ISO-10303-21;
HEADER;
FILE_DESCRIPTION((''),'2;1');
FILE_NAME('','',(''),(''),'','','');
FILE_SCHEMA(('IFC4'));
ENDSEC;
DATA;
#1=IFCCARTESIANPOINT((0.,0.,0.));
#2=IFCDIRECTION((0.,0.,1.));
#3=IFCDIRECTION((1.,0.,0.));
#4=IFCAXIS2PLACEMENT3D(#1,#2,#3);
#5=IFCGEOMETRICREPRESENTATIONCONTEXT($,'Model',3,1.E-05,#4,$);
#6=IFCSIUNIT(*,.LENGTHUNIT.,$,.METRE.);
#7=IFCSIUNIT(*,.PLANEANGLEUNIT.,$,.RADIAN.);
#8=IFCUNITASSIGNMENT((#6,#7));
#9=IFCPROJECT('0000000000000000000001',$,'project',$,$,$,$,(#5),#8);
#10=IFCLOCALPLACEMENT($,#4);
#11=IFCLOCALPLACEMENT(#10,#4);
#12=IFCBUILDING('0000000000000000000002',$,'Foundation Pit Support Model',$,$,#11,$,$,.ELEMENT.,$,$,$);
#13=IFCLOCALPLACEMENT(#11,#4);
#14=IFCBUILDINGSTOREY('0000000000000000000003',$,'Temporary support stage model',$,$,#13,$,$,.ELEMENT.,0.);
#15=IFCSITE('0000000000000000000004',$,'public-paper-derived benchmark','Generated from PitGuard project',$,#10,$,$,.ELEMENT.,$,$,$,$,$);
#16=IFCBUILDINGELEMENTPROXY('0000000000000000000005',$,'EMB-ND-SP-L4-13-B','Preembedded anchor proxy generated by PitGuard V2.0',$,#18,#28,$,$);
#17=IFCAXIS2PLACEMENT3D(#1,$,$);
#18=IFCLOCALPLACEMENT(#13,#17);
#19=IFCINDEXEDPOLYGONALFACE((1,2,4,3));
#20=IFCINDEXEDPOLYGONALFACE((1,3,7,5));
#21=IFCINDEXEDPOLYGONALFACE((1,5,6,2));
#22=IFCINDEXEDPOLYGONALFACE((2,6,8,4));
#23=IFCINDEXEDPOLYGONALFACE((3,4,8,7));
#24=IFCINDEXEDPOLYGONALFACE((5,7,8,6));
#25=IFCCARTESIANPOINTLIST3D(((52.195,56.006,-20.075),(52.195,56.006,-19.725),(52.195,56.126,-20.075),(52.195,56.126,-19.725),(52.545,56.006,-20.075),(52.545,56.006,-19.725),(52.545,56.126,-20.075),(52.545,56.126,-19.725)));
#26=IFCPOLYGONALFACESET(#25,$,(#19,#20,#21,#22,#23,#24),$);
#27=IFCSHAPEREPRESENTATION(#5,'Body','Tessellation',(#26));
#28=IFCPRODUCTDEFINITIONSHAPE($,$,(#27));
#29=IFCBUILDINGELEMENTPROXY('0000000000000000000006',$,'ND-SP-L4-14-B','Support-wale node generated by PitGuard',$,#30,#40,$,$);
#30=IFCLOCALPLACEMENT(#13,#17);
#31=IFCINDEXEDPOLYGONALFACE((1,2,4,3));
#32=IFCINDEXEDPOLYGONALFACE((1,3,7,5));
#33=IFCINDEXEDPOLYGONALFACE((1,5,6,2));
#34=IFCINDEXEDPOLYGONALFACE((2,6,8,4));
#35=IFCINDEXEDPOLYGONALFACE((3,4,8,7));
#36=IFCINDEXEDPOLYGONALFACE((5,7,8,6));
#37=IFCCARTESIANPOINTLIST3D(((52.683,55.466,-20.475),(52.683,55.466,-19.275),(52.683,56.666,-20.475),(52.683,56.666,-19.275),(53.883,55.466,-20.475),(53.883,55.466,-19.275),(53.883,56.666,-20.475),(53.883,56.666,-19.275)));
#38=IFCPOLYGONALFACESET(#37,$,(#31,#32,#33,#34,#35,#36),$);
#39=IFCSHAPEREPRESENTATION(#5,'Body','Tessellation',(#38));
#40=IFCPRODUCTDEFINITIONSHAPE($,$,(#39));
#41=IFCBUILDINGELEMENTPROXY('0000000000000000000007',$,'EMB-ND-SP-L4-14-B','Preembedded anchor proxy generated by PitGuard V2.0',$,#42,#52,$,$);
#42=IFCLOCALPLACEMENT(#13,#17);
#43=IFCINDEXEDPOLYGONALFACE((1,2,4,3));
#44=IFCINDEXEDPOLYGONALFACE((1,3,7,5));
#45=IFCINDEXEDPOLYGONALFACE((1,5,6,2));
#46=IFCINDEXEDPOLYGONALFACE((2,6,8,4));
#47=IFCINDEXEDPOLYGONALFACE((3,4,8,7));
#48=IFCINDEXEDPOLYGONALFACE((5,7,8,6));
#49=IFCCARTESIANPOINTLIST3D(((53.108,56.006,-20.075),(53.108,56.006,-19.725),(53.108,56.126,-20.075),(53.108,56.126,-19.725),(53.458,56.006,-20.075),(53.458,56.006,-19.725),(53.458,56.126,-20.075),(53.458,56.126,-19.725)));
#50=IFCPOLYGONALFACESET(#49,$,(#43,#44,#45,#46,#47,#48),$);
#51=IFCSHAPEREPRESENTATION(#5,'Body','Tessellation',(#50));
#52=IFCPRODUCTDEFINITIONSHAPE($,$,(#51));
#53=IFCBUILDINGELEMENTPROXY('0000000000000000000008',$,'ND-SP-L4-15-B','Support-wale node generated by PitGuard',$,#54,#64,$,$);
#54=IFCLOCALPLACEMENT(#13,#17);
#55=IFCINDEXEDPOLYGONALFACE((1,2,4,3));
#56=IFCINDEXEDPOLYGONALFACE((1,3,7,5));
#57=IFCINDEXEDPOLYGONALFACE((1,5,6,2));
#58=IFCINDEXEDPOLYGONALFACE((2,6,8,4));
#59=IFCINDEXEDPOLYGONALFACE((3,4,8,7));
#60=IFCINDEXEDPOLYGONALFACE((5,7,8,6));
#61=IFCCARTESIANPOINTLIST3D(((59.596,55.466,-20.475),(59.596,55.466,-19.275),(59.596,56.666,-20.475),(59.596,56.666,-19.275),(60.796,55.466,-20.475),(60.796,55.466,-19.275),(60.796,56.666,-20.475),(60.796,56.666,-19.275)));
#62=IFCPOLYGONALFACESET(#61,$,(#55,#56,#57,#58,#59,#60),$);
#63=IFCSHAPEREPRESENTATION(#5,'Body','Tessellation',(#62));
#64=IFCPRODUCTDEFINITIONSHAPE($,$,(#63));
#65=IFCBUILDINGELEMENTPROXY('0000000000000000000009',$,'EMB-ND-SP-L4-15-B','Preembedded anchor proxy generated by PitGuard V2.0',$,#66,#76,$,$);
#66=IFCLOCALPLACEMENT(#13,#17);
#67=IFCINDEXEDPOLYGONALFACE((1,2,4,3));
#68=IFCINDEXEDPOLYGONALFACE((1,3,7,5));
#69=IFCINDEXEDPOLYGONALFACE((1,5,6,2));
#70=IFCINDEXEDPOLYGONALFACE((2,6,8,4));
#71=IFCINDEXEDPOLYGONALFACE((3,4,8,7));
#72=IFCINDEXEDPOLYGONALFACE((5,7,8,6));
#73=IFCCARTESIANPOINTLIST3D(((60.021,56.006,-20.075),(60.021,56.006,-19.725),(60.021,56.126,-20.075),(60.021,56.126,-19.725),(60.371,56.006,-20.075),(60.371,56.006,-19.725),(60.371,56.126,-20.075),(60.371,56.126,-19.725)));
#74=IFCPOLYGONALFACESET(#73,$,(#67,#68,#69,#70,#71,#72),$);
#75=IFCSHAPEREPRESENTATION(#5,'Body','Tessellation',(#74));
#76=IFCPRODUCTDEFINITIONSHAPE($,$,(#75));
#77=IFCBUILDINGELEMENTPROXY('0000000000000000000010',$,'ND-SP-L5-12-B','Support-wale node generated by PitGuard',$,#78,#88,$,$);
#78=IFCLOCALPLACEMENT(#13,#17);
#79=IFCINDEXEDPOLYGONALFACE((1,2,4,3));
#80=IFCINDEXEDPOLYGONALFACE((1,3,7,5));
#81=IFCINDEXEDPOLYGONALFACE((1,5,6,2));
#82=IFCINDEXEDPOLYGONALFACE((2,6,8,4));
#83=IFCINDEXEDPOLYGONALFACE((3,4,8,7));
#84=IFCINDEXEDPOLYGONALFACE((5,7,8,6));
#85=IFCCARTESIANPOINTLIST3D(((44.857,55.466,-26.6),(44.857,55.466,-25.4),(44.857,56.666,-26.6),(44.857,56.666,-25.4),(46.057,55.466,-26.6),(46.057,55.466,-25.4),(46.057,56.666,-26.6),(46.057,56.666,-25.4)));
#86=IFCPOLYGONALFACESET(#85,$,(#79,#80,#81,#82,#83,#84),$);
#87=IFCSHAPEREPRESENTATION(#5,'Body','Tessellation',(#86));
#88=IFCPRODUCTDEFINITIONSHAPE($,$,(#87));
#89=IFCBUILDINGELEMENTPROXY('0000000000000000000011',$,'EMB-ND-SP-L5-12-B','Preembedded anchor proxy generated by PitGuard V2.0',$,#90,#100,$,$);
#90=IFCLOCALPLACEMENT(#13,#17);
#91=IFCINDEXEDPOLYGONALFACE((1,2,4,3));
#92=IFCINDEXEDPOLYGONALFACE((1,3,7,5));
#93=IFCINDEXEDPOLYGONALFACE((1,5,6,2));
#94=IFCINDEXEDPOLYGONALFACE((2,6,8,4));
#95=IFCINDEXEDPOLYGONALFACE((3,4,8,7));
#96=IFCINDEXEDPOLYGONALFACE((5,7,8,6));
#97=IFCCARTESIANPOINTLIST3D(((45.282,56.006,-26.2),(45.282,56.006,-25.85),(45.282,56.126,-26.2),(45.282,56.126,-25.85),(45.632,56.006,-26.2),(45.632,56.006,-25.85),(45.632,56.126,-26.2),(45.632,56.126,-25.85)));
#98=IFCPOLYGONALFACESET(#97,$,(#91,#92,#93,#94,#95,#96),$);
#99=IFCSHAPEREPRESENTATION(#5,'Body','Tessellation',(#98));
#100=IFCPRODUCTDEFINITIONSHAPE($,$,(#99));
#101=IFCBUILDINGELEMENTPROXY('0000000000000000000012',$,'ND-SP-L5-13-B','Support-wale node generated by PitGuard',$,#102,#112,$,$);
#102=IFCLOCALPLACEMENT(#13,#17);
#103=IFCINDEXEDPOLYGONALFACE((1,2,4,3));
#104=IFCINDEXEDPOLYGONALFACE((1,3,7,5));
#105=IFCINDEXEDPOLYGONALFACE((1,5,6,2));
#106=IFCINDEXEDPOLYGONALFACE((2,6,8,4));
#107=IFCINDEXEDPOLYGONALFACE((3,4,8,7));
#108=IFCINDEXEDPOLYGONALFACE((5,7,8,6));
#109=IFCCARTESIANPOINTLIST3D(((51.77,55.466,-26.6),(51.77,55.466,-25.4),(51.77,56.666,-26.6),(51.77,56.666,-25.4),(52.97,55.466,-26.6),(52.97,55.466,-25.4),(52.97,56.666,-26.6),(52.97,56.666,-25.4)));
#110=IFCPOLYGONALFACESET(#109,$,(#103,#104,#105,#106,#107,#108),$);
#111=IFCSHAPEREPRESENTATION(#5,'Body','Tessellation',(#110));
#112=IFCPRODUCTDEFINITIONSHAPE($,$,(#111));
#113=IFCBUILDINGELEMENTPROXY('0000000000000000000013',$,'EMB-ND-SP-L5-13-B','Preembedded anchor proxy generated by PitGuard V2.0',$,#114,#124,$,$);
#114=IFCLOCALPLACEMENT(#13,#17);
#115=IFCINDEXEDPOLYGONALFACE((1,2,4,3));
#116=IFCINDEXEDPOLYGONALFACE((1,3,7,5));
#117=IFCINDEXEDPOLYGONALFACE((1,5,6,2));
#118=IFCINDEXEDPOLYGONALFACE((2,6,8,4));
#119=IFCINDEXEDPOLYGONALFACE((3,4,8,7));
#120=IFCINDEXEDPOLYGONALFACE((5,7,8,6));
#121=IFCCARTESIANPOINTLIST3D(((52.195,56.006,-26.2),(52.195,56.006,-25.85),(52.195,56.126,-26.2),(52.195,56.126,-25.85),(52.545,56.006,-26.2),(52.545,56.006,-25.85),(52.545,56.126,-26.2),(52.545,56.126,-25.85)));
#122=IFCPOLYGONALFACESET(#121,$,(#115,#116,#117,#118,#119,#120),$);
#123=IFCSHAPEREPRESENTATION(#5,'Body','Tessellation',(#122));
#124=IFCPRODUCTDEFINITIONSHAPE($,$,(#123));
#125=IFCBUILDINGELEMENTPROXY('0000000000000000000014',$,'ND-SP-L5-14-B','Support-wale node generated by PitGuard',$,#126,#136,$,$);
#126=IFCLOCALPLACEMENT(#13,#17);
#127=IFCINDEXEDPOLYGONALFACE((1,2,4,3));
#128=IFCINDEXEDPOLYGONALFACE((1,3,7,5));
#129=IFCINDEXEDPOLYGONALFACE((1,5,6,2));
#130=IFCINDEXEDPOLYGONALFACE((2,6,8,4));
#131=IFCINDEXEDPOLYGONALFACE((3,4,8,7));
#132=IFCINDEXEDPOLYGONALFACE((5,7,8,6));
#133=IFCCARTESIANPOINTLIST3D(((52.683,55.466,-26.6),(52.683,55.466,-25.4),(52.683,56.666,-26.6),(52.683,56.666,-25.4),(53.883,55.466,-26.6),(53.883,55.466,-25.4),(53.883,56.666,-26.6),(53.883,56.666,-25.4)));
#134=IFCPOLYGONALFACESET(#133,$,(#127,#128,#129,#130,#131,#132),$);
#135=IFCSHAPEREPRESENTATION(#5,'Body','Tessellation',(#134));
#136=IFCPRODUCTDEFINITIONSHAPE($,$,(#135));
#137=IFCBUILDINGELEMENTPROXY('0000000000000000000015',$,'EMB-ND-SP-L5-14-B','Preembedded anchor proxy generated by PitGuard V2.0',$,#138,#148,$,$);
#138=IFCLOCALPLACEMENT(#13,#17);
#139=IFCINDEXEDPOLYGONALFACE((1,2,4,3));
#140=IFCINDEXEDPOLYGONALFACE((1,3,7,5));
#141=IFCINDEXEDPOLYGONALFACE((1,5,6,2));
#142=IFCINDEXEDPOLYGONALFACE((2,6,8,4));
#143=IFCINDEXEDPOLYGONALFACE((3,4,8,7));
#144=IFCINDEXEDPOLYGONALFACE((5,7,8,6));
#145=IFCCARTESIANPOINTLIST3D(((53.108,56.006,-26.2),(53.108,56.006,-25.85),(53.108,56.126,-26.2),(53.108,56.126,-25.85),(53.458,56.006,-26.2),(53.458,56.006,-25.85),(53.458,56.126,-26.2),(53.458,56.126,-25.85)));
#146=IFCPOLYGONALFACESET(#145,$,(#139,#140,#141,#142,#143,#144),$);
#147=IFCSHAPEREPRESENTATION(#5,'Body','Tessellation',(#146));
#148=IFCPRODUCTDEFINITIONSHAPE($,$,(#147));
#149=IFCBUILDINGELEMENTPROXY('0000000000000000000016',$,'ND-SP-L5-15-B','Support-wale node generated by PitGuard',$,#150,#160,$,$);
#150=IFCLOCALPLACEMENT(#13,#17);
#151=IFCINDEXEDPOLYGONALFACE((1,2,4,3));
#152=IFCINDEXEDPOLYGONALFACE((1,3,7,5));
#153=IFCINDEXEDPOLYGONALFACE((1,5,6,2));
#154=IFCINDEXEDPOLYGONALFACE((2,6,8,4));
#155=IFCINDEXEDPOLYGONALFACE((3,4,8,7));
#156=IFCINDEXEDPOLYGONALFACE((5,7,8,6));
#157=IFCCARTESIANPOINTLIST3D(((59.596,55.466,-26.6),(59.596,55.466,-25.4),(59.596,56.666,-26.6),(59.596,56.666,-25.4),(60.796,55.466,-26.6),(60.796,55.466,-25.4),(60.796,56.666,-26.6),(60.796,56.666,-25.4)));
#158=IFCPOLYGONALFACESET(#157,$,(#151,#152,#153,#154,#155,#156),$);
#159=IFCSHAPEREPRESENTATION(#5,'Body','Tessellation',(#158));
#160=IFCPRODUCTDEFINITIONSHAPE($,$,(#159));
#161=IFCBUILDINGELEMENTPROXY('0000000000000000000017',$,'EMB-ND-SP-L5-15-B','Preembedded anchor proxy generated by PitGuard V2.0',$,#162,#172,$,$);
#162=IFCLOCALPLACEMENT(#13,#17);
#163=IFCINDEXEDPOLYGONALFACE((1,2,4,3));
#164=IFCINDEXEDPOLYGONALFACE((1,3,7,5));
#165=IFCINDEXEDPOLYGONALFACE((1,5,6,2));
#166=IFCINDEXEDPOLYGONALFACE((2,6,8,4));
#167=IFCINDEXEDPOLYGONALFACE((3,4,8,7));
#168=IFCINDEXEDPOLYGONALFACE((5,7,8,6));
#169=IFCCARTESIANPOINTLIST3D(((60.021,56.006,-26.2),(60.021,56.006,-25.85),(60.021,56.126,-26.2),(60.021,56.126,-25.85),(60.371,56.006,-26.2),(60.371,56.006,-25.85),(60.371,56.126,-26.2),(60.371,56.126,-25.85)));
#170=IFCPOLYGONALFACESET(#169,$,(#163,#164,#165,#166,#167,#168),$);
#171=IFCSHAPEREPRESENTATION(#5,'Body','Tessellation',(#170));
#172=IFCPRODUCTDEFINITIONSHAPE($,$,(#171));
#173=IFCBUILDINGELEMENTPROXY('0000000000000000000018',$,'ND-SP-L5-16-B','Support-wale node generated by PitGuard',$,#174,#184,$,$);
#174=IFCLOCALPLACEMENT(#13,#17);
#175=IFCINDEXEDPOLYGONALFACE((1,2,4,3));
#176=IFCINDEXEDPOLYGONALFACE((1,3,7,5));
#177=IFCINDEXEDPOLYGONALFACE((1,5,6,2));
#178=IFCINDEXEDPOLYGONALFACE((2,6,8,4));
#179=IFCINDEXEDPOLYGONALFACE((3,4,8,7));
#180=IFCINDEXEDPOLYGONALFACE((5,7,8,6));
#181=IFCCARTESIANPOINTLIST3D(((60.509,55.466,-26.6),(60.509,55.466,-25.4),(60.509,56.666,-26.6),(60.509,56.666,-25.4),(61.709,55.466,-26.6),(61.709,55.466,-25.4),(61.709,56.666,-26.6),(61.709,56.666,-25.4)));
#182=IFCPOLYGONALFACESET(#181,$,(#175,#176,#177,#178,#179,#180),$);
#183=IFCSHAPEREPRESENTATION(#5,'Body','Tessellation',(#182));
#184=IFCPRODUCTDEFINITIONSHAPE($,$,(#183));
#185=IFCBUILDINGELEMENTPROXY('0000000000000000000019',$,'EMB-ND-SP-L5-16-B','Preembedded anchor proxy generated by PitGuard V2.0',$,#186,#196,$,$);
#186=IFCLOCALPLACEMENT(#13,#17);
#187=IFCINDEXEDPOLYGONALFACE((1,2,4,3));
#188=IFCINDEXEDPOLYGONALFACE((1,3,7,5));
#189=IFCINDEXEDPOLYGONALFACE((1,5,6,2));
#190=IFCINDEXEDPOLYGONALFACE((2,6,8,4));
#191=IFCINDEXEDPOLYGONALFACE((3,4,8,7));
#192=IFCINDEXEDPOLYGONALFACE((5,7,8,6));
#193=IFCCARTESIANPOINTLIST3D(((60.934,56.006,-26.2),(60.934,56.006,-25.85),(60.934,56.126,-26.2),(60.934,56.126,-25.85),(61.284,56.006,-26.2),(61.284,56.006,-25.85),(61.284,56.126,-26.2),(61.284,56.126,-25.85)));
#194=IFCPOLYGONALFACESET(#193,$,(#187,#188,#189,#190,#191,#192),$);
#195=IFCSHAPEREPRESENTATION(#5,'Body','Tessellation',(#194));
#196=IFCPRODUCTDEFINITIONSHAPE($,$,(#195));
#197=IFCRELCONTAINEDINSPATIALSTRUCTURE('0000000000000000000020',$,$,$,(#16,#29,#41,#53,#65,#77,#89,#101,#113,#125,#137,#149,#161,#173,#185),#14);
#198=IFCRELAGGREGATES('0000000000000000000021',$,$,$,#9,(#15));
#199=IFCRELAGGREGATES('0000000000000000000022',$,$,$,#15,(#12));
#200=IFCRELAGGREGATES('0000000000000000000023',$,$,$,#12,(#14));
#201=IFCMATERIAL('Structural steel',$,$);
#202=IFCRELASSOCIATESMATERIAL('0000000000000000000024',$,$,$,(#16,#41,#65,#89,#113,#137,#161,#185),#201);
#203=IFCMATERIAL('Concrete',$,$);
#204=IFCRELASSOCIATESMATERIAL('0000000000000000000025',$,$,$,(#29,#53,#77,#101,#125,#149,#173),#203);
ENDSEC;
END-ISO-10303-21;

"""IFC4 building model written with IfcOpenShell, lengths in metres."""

from ifc_helpers import new_model, si_unit, frame, origin_with_axes, origin_2d, place, context, project, spatial, rectangle, extrude, material, element, save


model = new_model("IFC4")

# Units and contexts
model_context = context("Model", 3, precision=1e-05, world=origin_with_axes())
ifc_project = project(units=[si_unit("LENGTHUNIT", "METRE"), si_unit("PLANEANGLEUNIT", "RADIAN")], contexts=[model_context])

# Site, building, storey
site_placement = place(None, origin_with_axes())
site = spatial("IfcSite", under=ifc_project, at=site_placement, Name="public-paper-derived benchmark", Description="Generated from PitGuard project", CompositionType="ELEMENT")
building_placement = place(site_placement, origin_with_axes())
building = spatial("IfcBuilding", under=site, at=building_placement, Name="Foundation Pit Support Model", CompositionType="ELEMENT")
storey_placement = place(building_placement, origin_with_axes())
storey = spatial("IfcBuildingStorey", under=building, at=storey_placement, Name="Temporary support stage model", CompositionType="ELEMENT", Elevation=0.0)

# Shared definitions
ifc_material_1 = material(Name="Structural steel")

# Shared definitions
ifc_material_2 = material(Name="Concrete")

# Building element proxies
proxy_1_placement = place(storey_placement, frame((52.37, 56.066, -20.075), z_axis=(0.0, 0.0, 1.0), x_axis=(1.0, 0.0, 0.0)))
element("IfcBuildingElementProxy", 1, at=proxy_1_placement, inside=storey, material=ifc_material_1, Name="EMB-ND-SP-L4-13-B", Description="Preembedded anchor proxy generated by PitGuard V2.0", context=model_context, shape_type="SweptSolid", body=[
    extrude(rectangle(XDim=0.35, YDim=0.12, at=origin_2d()), origin_with_axes(), (0.0, 0.0, 1.0), 0.35),
])
proxy_2_placement = place(storey_placement, frame((53.283, 56.066, -20.475), z_axis=(0.0, 0.0, 1.0), x_axis=(1.0, 0.0, 0.0)))
element("IfcBuildingElementProxy", 2, at=proxy_2_placement, inside=storey, material=ifc_material_2, Name="ND-SP-L4-14-B", Description="Support-wale node generated by PitGuard", context=model_context, shape_type="SweptSolid", body=[
    extrude(rectangle(XDim=1.2, YDim=1.2, at=origin_2d()), origin_with_axes(), (0.0, 0.0, 1.0), 1.2),
])
proxy_3_placement = place(storey_placement, frame((53.283, 56.066, -20.075), z_axis=(0.0, 0.0, 1.0), x_axis=(1.0, 0.0, 0.0)))
element("IfcBuildingElementProxy", 3, at=proxy_3_placement, inside=storey, material=ifc_material_1, Name="EMB-ND-SP-L4-14-B", Description="Preembedded anchor proxy generated by PitGuard V2.0", context=model_context, shape_type="SweptSolid", body=[
    extrude(rectangle(XDim=0.35, YDim=0.12, at=origin_2d()), origin_with_axes(), (0.0, 0.0, 1.0), 0.35),
])
proxy_4_placement = place(storey_placement, frame((60.196, 56.066, -20.475), z_axis=(0.0, 0.0, 1.0), x_axis=(1.0, 0.0, 0.0)))
element("IfcBuildingElementProxy", 4, at=proxy_4_placement, inside=storey, material=ifc_material_2, Name="ND-SP-L4-15-B", Description="Support-wale node generated by PitGuard", context=model_context, shape_type="SweptSolid", body=[
    extrude(rectangle(XDim=1.2, YDim=1.2, at=origin_2d()), origin_with_axes(), (0.0, 0.0, 1.0), 1.2),
])
proxy_5_placement = place(storey_placement, frame((60.196, 56.066, -20.075), z_axis=(0.0, 0.0, 1.0), x_axis=(1.0, 0.0, 0.0)))
element("IfcBuildingElementProxy", 5, at=proxy_5_placement, inside=storey, material=ifc_material_1, Name="EMB-ND-SP-L4-15-B", Description="Preembedded anchor proxy generated by PitGuard V2.0", context=model_context, shape_type="SweptSolid", body=[
    extrude(rectangle(XDim=0.35, YDim=0.12, at=origin_2d()), origin_with_axes(), (0.0, 0.0, 1.0), 0.35),
])
proxy_6_placement = place(storey_placement, frame((45.457, 56.066, -26.6), z_axis=(0.0, 0.0, 1.0), x_axis=(1.0, 0.0, 0.0)))
element("IfcBuildingElementProxy", 6, at=proxy_6_placement, inside=storey, material=ifc_material_2, Name="ND-SP-L5-12-B", Description="Support-wale node generated by PitGuard", context=model_context, shape_type="SweptSolid", body=[
    extrude(rectangle(XDim=1.2, YDim=1.2, at=origin_2d()), origin_with_axes(), (0.0, 0.0, 1.0), 1.2),
])
proxy_7_placement = place(storey_placement, frame((45.457, 56.066, -26.2), z_axis=(0.0, 0.0, 1.0), x_axis=(1.0, 0.0, 0.0)))
element("IfcBuildingElementProxy", 7, at=proxy_7_placement, inside=storey, material=ifc_material_1, Name="EMB-ND-SP-L5-12-B", Description="Preembedded anchor proxy generated by PitGuard V2.0", context=model_context, shape_type="SweptSolid", body=[
    extrude(rectangle(XDim=0.35, YDim=0.12, at=origin_2d()), origin_with_axes(), (0.0, 0.0, 1.0), 0.35),
])
proxy_8_placement = place(storey_placement, frame((52.37, 56.066, -26.6), z_axis=(0.0, 0.0, 1.0), x_axis=(1.0, 0.0, 0.0)))
element("IfcBuildingElementProxy", 8, at=proxy_8_placement, inside=storey, material=ifc_material_2, Name="ND-SP-L5-13-B", Description="Support-wale node generated by PitGuard", context=model_context, shape_type="SweptSolid", body=[
    extrude(rectangle(XDim=1.2, YDim=1.2, at=origin_2d()), origin_with_axes(), (0.0, 0.0, 1.0), 1.2),
])
proxy_9_placement = place(storey_placement, frame((52.37, 56.066, -26.2), z_axis=(0.0, 0.0, 1.0), x_axis=(1.0, 0.0, 0.0)))
element("IfcBuildingElementProxy", 9, at=proxy_9_placement, inside=storey, material=ifc_material_1, Name="EMB-ND-SP-L5-13-B", Description="Preembedded anchor proxy generated by PitGuard V2.0", context=model_context, shape_type="SweptSolid", body=[
    extrude(rectangle(XDim=0.35, YDim=0.12, at=origin_2d()), origin_with_axes(), (0.0, 0.0, 1.0), 0.35),
])
proxy_10_placement = place(storey_placement, frame((53.283, 56.066, -26.6), z_axis=(0.0, 0.0, 1.0), x_axis=(1.0, 0.0, 0.0)))
element("IfcBuildingElementProxy", 10, at=proxy_10_placement, inside=storey, material=ifc_material_2, Name="ND-SP-L5-14-B", Description="Support-wale node generated by PitGuard", context=model_context, shape_type="SweptSolid", body=[
    extrude(rectangle(XDim=1.2, YDim=1.2, at=origin_2d()), origin_with_axes(), (0.0, 0.0, 1.0), 1.2),
])
proxy_11_placement = place(storey_placement, frame((53.283, 56.066, -26.2), z_axis=(0.0, 0.0, 1.0), x_axis=(1.0, 0.0, 0.0)))
element("IfcBuildingElementProxy", 11, at=proxy_11_placement, inside=storey, material=ifc_material_1, Name="EMB-ND-SP-L5-14-B", Description="Preembedded anchor proxy generated by PitGuard V2.0", context=model_context, shape_type="SweptSolid", body=[
    extrude(rectangle(XDim=0.35, YDim=0.12, at=origin_2d()), origin_with_axes(), (0.0, 0.0, 1.0), 0.35),
])
proxy_12_placement = place(storey_placement, frame((60.196, 56.066, -26.6), z_axis=(0.0, 0.0, 1.0), x_axis=(1.0, 0.0, 0.0)))
element("IfcBuildingElementProxy", 12, at=proxy_12_placement, inside=storey, material=ifc_material_2, Name="ND-SP-L5-15-B", Description="Support-wale node generated by PitGuard", context=model_context, shape_type="SweptSolid", body=[
    extrude(rectangle(XDim=1.2, YDim=1.2, at=origin_2d()), origin_with_axes(), (0.0, 0.0, 1.0), 1.2),
])
proxy_13_placement = place(storey_placement, frame((60.196, 56.066, -26.2), z_axis=(0.0, 0.0, 1.0), x_axis=(1.0, 0.0, 0.0)))
element("IfcBuildingElementProxy", 13, at=proxy_13_placement, inside=storey, material=ifc_material_1, Name="EMB-ND-SP-L5-15-B", Description="Preembedded anchor proxy generated by PitGuard V2.0", context=model_context, shape_type="SweptSolid", body=[
    extrude(rectangle(XDim=0.35, YDim=0.12, at=origin_2d()), origin_with_axes(), (0.0, 0.0, 1.0), 0.35),
])
proxy_14_placement = place(storey_placement, frame((61.109, 56.066, -26.6), z_axis=(0.0, 0.0, 1.0), x_axis=(1.0, 0.0, 0.0)))
element("IfcBuildingElementProxy", 14, at=proxy_14_placement, inside=storey, material=ifc_material_2, Name="ND-SP-L5-16-B", Description="Support-wale node generated by PitGuard", context=model_context, shape_type="SweptSolid", body=[
    extrude(rectangle(XDim=1.2, YDim=1.2, at=origin_2d()), origin_with_axes(), (0.0, 0.0, 1.0), 1.2),
])
proxy_15_placement = place(storey_placement, frame((61.109, 56.066, -26.2), z_axis=(0.0, 0.0, 1.0), x_axis=(1.0, 0.0, 0.0)))
element("IfcBuildingElementProxy", 15, at=proxy_15_placement, inside=storey, material=ifc_material_1, Name="EMB-ND-SP-L5-16-B", Description="Preembedded anchor proxy generated by PitGuard V2.0", context=model_context, shape_type="SweptSolid", body=[
    extrude(rectangle(XDim=0.35, YDim=0.12, at=origin_2d()), origin_with_axes(), (0.0, 0.0, 1.0), 0.35),
])

save(model, "model.ifc")
